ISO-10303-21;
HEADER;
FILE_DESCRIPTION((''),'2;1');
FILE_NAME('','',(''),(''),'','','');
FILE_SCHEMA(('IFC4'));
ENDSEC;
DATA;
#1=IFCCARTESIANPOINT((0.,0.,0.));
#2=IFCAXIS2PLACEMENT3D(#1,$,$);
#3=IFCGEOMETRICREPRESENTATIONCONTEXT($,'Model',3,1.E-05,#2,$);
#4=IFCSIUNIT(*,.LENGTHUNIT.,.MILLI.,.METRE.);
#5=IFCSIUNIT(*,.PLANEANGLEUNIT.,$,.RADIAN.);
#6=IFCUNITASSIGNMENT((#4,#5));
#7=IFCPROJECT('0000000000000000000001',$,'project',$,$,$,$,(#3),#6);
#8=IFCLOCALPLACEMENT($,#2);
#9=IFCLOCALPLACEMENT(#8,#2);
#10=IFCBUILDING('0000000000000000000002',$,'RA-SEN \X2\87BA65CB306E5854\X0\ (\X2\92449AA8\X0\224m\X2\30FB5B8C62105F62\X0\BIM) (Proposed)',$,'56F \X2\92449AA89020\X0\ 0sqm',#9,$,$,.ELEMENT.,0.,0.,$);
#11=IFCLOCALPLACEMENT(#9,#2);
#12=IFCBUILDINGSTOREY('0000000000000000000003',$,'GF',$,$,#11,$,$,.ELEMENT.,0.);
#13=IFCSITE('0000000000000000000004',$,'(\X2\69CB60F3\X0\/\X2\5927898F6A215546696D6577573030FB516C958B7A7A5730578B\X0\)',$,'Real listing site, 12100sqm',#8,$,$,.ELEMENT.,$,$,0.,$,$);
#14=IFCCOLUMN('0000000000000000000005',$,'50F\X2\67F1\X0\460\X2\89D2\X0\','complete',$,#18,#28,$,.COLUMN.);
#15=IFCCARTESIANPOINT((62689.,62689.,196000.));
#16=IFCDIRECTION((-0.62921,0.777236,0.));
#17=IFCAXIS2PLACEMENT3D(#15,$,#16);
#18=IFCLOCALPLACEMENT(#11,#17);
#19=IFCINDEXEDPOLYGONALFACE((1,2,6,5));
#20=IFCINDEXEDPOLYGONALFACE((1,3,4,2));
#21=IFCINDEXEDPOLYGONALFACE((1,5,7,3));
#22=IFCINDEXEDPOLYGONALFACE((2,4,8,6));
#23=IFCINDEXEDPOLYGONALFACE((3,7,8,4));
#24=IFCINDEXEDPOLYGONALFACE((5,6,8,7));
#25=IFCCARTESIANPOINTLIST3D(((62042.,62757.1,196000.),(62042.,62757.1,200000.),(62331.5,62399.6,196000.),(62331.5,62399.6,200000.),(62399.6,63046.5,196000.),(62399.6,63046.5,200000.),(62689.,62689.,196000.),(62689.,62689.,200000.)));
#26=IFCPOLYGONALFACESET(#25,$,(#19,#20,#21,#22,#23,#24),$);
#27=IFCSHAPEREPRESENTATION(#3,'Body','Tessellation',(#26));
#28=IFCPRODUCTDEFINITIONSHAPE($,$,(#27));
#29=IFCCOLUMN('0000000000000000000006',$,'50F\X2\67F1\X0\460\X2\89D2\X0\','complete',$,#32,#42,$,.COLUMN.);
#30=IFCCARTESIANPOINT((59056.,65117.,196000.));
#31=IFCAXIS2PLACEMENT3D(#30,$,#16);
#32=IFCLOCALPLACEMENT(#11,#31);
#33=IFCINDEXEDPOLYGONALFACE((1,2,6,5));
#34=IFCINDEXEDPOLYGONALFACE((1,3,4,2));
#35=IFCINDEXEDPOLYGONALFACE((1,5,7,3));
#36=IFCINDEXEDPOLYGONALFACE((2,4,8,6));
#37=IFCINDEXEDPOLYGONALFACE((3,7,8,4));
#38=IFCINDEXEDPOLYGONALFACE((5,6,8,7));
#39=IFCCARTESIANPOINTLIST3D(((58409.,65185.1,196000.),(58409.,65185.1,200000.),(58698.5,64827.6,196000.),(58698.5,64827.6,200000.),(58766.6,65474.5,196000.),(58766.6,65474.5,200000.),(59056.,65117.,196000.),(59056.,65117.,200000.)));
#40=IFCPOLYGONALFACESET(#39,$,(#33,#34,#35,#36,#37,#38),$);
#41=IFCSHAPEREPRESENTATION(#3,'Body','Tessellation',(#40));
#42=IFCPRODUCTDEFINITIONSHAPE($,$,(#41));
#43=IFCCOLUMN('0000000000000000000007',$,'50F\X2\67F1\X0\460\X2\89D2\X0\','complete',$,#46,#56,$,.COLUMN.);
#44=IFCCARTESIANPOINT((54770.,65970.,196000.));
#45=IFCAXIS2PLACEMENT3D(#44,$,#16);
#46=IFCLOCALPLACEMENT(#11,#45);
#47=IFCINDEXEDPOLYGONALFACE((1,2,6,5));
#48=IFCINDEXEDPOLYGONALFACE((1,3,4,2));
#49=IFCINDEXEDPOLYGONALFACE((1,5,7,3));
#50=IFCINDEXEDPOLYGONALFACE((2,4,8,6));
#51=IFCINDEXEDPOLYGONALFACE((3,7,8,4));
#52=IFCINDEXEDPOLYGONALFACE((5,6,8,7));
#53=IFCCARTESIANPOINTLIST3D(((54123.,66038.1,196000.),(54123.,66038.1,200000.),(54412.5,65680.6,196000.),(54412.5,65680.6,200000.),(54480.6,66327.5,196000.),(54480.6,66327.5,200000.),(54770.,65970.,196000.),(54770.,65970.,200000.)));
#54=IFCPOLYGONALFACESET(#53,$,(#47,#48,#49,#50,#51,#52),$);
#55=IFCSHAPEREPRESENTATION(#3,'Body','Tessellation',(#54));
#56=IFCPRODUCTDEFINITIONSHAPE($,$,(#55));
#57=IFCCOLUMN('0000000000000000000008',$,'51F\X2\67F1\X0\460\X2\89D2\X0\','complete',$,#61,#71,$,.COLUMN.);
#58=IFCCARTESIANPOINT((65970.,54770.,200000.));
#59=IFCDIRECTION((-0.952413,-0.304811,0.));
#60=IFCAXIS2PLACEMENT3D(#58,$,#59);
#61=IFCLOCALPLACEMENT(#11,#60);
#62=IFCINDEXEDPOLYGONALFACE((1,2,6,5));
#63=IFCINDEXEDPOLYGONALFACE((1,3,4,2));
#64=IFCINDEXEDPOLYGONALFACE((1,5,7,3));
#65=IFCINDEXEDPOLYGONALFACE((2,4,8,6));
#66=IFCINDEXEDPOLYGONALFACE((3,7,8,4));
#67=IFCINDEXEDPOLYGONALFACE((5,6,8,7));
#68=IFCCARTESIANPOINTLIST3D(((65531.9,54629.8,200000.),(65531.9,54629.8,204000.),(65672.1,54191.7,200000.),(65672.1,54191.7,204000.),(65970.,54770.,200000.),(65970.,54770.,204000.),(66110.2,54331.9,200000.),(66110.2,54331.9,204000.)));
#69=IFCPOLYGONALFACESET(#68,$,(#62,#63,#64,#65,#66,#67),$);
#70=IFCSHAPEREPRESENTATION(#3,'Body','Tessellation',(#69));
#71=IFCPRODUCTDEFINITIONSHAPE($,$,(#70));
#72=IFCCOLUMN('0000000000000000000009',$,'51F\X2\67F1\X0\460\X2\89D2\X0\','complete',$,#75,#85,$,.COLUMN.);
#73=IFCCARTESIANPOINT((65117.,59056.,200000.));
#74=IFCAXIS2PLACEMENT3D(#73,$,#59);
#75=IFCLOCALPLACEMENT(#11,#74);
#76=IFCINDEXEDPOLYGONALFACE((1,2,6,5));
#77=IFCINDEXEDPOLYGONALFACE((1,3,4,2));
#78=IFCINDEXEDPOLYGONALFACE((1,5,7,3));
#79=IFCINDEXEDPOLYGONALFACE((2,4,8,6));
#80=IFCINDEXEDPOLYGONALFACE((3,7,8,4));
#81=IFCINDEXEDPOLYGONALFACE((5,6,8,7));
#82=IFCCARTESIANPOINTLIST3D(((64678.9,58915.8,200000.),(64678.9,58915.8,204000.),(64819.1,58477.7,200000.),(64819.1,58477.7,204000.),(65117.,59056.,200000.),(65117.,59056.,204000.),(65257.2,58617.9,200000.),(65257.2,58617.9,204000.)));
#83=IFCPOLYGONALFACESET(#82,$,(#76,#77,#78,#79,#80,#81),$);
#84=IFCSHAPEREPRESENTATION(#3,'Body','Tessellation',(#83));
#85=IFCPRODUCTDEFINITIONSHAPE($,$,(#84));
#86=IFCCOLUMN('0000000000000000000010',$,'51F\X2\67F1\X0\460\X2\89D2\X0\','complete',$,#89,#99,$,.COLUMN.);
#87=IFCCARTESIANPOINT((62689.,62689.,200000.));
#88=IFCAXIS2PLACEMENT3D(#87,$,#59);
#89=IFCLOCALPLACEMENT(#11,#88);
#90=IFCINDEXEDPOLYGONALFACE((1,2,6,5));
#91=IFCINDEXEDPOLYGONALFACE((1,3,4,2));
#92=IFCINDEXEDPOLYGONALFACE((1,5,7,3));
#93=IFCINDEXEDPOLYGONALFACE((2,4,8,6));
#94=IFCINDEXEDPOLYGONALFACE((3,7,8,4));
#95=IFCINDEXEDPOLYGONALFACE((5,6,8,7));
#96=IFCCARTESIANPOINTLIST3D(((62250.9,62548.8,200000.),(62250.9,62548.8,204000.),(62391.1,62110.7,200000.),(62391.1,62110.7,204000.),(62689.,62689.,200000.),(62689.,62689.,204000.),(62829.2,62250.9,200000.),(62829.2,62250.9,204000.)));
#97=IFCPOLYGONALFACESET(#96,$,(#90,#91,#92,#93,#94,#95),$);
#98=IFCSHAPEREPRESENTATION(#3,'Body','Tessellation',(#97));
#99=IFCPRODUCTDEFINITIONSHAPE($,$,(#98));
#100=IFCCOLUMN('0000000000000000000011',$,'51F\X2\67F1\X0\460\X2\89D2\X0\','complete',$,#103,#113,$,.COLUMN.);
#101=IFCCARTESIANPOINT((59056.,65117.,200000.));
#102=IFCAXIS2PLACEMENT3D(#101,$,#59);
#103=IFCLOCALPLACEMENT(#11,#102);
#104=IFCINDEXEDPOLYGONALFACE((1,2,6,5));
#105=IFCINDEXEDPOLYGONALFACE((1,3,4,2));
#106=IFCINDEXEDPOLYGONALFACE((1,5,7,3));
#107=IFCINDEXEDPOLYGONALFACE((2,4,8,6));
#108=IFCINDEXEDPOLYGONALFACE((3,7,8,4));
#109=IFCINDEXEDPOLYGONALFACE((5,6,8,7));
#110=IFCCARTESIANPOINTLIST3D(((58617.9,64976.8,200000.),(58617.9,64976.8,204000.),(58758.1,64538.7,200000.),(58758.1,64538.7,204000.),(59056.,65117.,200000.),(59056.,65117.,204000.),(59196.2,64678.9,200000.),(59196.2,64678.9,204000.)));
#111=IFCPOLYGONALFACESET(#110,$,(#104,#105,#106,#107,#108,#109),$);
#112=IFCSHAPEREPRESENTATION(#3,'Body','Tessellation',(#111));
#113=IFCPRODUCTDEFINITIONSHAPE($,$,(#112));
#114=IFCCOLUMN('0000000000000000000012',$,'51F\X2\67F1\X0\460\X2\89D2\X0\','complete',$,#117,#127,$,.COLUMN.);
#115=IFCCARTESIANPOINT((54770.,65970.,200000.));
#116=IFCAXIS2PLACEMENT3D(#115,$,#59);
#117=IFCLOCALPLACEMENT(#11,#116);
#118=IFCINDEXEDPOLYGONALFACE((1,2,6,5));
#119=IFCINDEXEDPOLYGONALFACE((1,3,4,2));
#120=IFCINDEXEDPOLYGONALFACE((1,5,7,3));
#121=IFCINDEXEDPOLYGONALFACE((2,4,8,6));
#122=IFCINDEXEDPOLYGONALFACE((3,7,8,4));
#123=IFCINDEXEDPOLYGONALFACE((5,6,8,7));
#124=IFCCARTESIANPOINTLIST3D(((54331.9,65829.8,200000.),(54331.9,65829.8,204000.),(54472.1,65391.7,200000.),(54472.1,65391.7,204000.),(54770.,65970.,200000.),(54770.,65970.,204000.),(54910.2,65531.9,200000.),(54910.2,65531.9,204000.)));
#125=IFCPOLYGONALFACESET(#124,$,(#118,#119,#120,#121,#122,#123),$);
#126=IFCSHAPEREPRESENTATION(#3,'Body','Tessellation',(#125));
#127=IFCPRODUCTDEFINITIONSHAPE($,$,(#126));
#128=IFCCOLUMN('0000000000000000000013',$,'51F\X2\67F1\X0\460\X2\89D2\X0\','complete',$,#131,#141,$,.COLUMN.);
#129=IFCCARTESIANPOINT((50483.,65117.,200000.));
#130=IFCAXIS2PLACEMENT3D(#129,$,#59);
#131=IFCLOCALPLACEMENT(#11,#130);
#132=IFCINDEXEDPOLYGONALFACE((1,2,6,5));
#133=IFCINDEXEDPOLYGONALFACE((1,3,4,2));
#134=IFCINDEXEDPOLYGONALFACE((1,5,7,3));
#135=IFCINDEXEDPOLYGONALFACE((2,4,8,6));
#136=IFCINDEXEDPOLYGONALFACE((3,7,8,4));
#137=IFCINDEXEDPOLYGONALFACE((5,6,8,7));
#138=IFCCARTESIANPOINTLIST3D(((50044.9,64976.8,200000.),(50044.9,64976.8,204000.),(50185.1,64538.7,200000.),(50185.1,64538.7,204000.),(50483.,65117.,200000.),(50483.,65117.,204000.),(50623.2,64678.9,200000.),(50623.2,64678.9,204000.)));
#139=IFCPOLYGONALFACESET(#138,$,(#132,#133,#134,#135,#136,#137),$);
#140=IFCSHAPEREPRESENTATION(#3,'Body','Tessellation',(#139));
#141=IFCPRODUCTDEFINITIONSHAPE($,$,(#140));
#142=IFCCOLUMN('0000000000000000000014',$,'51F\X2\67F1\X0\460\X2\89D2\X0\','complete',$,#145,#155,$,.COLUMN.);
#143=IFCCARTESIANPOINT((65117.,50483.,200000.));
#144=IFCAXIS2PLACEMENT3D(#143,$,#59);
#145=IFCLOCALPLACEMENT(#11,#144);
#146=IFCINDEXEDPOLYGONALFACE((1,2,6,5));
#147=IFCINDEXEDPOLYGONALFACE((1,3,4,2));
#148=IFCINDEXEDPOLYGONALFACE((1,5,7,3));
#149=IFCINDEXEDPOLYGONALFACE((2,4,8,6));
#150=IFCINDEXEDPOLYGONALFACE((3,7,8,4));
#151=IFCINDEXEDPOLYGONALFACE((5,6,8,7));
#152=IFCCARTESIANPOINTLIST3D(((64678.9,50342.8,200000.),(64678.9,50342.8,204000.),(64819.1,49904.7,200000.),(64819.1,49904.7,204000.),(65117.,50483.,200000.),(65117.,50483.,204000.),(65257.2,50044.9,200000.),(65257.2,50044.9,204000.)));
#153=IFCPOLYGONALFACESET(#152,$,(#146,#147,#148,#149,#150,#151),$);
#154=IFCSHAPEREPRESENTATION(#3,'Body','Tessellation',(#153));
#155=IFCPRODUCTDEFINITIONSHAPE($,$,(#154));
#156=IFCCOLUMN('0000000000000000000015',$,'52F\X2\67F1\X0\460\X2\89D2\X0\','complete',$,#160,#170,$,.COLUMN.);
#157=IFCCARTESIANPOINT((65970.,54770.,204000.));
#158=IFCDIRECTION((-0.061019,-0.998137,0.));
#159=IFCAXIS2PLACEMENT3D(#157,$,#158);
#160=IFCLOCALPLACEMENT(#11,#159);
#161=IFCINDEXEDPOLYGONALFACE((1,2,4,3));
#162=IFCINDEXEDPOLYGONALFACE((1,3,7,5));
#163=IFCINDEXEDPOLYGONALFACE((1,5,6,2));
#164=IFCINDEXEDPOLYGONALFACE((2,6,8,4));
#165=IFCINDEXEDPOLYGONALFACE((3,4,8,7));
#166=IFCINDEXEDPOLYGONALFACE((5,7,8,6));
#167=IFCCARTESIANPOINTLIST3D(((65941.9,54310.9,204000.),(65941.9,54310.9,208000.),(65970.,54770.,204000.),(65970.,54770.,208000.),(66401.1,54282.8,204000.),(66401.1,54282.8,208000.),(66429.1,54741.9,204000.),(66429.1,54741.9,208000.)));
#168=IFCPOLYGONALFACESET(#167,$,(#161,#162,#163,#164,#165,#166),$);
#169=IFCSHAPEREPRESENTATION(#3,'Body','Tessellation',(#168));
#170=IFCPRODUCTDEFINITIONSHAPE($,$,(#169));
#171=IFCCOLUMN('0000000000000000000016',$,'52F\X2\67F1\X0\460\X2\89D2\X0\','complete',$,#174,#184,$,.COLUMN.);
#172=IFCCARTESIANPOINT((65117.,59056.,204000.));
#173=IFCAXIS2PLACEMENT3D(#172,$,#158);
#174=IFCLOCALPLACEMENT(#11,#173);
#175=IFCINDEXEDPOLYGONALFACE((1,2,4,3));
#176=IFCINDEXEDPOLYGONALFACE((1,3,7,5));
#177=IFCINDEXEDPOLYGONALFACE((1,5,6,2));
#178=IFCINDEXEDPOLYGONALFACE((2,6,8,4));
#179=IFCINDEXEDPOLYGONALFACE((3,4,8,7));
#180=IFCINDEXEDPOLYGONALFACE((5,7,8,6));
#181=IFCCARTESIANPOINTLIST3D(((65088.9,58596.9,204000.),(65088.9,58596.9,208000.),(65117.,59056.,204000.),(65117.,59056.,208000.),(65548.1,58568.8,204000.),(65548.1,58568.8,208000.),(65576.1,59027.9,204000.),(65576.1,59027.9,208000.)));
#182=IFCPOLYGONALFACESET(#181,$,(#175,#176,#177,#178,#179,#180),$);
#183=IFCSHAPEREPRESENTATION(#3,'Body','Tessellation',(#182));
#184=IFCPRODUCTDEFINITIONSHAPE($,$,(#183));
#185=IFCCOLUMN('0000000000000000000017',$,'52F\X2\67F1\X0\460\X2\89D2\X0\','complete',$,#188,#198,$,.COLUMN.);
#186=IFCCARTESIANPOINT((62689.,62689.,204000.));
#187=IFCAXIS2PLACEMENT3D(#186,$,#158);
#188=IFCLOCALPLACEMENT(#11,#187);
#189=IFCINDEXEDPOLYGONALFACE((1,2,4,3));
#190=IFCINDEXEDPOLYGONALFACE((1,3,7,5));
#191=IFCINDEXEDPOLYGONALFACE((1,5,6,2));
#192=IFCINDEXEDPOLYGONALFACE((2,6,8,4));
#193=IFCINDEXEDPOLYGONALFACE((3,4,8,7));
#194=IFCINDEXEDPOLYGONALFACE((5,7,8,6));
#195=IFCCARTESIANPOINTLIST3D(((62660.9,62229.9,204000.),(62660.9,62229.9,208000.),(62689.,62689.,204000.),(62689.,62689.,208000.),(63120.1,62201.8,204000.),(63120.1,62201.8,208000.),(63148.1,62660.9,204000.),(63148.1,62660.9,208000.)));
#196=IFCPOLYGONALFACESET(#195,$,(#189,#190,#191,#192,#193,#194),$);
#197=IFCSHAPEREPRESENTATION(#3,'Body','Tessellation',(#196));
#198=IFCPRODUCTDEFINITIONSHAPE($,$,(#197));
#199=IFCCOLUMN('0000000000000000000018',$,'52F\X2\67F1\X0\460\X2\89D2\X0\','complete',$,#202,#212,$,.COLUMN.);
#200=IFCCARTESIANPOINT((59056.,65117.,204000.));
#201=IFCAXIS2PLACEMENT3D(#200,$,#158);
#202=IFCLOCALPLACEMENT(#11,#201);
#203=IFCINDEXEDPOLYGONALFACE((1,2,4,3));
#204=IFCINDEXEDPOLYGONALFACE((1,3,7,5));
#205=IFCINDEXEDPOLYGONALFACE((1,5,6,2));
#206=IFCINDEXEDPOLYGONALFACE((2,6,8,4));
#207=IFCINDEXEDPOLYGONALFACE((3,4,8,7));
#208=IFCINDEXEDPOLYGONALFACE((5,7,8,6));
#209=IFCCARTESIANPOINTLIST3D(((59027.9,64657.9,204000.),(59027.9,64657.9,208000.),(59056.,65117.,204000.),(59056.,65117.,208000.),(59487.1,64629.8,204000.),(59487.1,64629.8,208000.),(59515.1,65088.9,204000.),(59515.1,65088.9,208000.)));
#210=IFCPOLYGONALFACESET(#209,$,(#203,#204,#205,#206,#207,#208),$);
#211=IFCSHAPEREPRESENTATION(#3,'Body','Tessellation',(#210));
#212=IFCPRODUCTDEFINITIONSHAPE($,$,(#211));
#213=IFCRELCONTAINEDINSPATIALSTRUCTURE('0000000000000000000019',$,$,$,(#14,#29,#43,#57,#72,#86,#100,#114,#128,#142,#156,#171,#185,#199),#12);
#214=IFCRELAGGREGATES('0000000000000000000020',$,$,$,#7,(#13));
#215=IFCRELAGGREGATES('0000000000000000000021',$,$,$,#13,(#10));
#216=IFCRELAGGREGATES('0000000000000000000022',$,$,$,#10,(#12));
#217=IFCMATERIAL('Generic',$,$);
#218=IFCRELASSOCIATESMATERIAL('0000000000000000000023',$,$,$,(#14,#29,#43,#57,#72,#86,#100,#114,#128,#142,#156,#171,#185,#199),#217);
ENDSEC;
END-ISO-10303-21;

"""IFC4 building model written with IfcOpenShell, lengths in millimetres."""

from ifc_helpers import new_model, si_unit, frame, frame_2d, origin, place, context, project, spatial, rectangle, extrude, material, element, save


model = new_model("IFC4")

# Units and contexts
model_context = context("Model", 3, precision=1e-05, world=origin())
ifc_project = project(units=[si_unit("LENGTHUNIT", "METRE", prefix="MILLI"), si_unit("PLANEANGLEUNIT", "RADIAN")], contexts=[model_context])

# Site, building, storey
site_placement = place(None, origin())
site = spatial("IfcSite", under=ifc_project, at=site_placement, Name="(構想/大規模商業敷地・公開空地型)", ObjectType="Real listing site, 12100sqm", CompositionType="ELEMENT", RefElevation=0.0)
building_placement = place(site_placement, origin())
building = spatial("IfcBuilding", under=site, at=building_placement, Name="RA-SEN 螺旋の塔 (鉄骨224m・完成形BIM) (Proposed)", ObjectType="56F 鉄骨造 0sqm", CompositionType="ELEMENT", ElevationOfRefHeight=0.0, ElevationOfTerrain=0.0)
storey_placement = place(building_placement, origin())
storey = spatial("IfcBuildingStorey", under=building, at=storey_placement, Name="GF", CompositionType="ELEMENT", Elevation=0.0)

# Columns
ifc_material = material(Name="Generic")
column_1_placement = place(storey_placement, frame((62689.0, 62689.0, 196000.0), x_axis=(-0.62921, 0.777236, 0.0)))
element("IfcColumn", 1, at=column_1_placement, inside=storey, material=ifc_material, Name="50F柱460角", Description="complete", PredefinedType="COLUMN", context=model_context, shape_type="SweptSolid", body=[
    extrude(rectangle(XDim=460.0, YDim=460.0, at=frame_2d((230.0, 230.0))), frame((62689.0, 62689.0, 196000.0), x_axis=(-0.62921, 0.777236, 0.0)), (0.0, 0.0, 1.0), 4000.0),
])
column_2_placement = place(storey_placement, frame((59056.0, 65117.0, 196000.0), x_axis=(-0.62921, 0.777236, 0.0)))
element("IfcColumn", 2, at=column_2_placement, inside=storey, material=ifc_material, Name="50F柱460角", Description="complete", PredefinedType="COLUMN", context=model_context, shape_type="SweptSolid", body=[
    extrude(rectangle(XDim=460.0, YDim=460.0, at=frame_2d((230.0, 230.0))), frame((59056.0, 65117.0, 196000.0), x_axis=(-0.62921, 0.777236, 0.0)), (0.0, 0.0, 1.0), 4000.0),
])
column_3_placement = place(storey_placement, frame((54770.0, 65970.0, 196000.0), x_axis=(-0.62921, 0.777236, 0.0)))
element("IfcColumn", 3, at=column_3_placement, inside=storey, material=ifc_material, Name="50F柱460角", Description="complete", PredefinedType="COLUMN", context=model_context, shape_type="SweptSolid", body=[
    extrude(rectangle(XDim=460.0, YDim=460.0, at=frame_2d((230.0, 230.0))), frame((54770.0, 65970.0, 196000.0), x_axis=(-0.62921, 0.777236, 0.0)), (0.0, 0.0, 1.0), 4000.0),
])
column_4_placement = place(storey_placement, frame((65970.0, 54770.0, 200000.0), x_axis=(-0.952413, -0.304811, 0.0)))
element("IfcColumn", 4, at=column_4_placement, inside=storey, material=ifc_material, Name="51F柱460角", Description="complete", PredefinedType="COLUMN", context=model_context, shape_type="SweptSolid", body=[
    extrude(rectangle(XDim=460.0, YDim=460.0, at=frame_2d((230.0, 230.0))), frame((65970.0, 54770.0, 200000.0), x_axis=(-0.952413, -0.304811, 0.0)), (0.0, 0.0, 1.0), 4000.0),
])
column_5_placement = place(storey_placement, frame((65117.0, 59056.0, 200000.0), x_axis=(-0.952413, -0.304811, 0.0)))
element("IfcColumn", 5, at=column_5_placement, inside=storey, material=ifc_material, Name="51F柱460角", Description="complete", PredefinedType="COLUMN", context=model_context, shape_type="SweptSolid", body=[
    extrude(rectangle(XDim=460.0, YDim=460.0, at=frame_2d((230.0, 230.0))), frame((65117.0, 59056.0, 200000.0), x_axis=(-0.952413, -0.304811, 0.0)), (0.0, 0.0, 1.0), 4000.0),
])
column_6_placement = place(storey_placement, frame((62689.0, 62689.0, 200000.0), x_axis=(-0.952413, -0.304811, 0.0)))
element("IfcColumn", 6, at=column_6_placement, inside=storey, material=ifc_material, Name="51F柱460角", Description="complete", PredefinedType="COLUMN", context=model_context, shape_type="SweptSolid", body=[
    extrude(rectangle(XDim=460.0, YDim=460.0, at=frame_2d((230.0, 230.0))), frame((62689.0, 62689.0, 200000.0), x_axis=(-0.952413, -0.304811, 0.0)), (0.0, 0.0, 1.0), 4000.0),
])
column_7_placement = place(storey_placement, frame((59056.0, 65117.0, 200000.0), x_axis=(-0.952413, -0.304811, 0.0)))
element("IfcColumn", 7, at=column_7_placement, inside=storey, material=ifc_material, Name="51F柱460角", Description="complete", PredefinedType="COLUMN", context=model_context, shape_type="SweptSolid", body=[
    extrude(rectangle(XDim=460.0, YDim=460.0, at=frame_2d((230.0, 230.0))), frame((59056.0, 65117.0, 200000.0), x_axis=(-0.952413, -0.304811, 0.0)), (0.0, 0.0, 1.0), 4000.0),
])
column_8_placement = place(storey_placement, frame((54770.0, 65970.0, 200000.0), x_axis=(-0.952413, -0.304811, 0.0)))
element("IfcColumn", 8, at=column_8_placement, inside=storey, material=ifc_material, Name="51F柱460角", Description="complete", PredefinedType="COLUMN", context=model_context, shape_type="SweptSolid", body=[
    extrude(rectangle(XDim=460.0, YDim=460.0, at=frame_2d((230.0, 230.0))), frame((54770.0, 65970.0, 200000.0), x_axis=(-0.952413, -0.304811, 0.0)), (0.0, 0.0, 1.0), 4000.0),
])
column_9_placement = place(storey_placement, frame((50483.0, 65117.0, 200000.0), x_axis=(-0.952413, -0.304811, 0.0)))
element("IfcColumn", 9, at=column_9_placement, inside=storey, material=ifc_material, Name="51F柱460角", Description="complete", PredefinedType="COLUMN", context=model_context, shape_type="SweptSolid", body=[
    extrude(rectangle(XDim=460.0, YDim=460.0, at=frame_2d((230.0, 230.0))), frame((50483.0, 65117.0, 200000.0), x_axis=(-0.952413, -0.304811, 0.0)), (0.0, 0.0, 1.0), 4000.0),
])
column_10_placement = place(storey_placement, frame((65117.0, 50483.0, 200000.0), x_axis=(-0.952413, -0.304811, 0.0)))
element("IfcColumn", 10, at=column_10_placement, inside=storey, material=ifc_material, Name="51F柱460角", Description="complete", PredefinedType="COLUMN", context=model_context, shape_type="SweptSolid", body=[
    extrude(rectangle(XDim=460.0, YDim=460.0, at=frame_2d((230.0, 230.0))), frame((65117.0, 50483.0, 200000.0), x_axis=(-0.952413, -0.304811, 0.0)), (0.0, 0.0, 1.0), 4000.0),
])
column_11_placement = place(storey_placement, frame((65970.0, 54770.0, 204000.0), x_axis=(-0.061019, -0.998137, 0.0)))
element("IfcColumn", 11, at=column_11_placement, inside=storey, material=ifc_material, Name="52F柱460角", Description="complete", PredefinedType="COLUMN", context=model_context, shape_type="SweptSolid", body=[
    extrude(rectangle(XDim=460.0, YDim=460.0, at=frame_2d((230.0, 230.0))), frame((65970.0, 54770.0, 204000.0), x_axis=(-0.061019, -0.998137, 0.0)), (0.0, 0.0, 1.0), 4000.0),
])
column_12_placement = place(storey_placement, frame((65117.0, 59056.0, 204000.0), x_axis=(-0.061019, -0.998137, 0.0)))
element("IfcColumn", 12, at=column_12_placement, inside=storey, material=ifc_material, Name="52F柱460角", Description="complete", PredefinedType="COLUMN", context=model_context, shape_type="SweptSolid", body=[
    extrude(rectangle(XDim=460.0, YDim=460.0, at=frame_2d((230.0, 230.0))), frame((65117.0, 59056.0, 204000.0), x_axis=(-0.061019, -0.998137, 0.0)), (0.0, 0.0, 1.0), 4000.0),
])
column_13_placement = place(storey_placement, frame((62689.0, 62689.0, 204000.0), x_axis=(-0.061019, -0.998137, 0.0)))
element("IfcColumn", 13, at=column_13_placement, inside=storey, material=ifc_material, Name="52F柱460角", Description="complete", PredefinedType="COLUMN", context=model_context, shape_type="SweptSolid", body=[
    extrude(rectangle(XDim=460.0, YDim=460.0, at=frame_2d((230.0, 230.0))), frame((62689.0, 62689.0, 204000.0), x_axis=(-0.061019, -0.998137, 0.0)), (0.0, 0.0, 1.0), 4000.0),
])
column_14_placement = place(storey_placement, frame((59056.0, 65117.0, 204000.0), x_axis=(-0.061019, -0.998137, 0.0)))
element("IfcColumn", 14, at=column_14_placement, inside=storey, material=ifc_material, Name="52F柱460角", Description="complete", PredefinedType="COLUMN", context=model_context, shape_type="SweptSolid", body=[
    extrude(rectangle(XDim=460.0, YDim=460.0, at=frame_2d((230.0, 230.0))), frame((59056.0, 65117.0, 204000.0), x_axis=(-0.061019, -0.998137, 0.0)), (0.0, 0.0, 1.0), 4000.0),
])

save(model, "model.ifc")
